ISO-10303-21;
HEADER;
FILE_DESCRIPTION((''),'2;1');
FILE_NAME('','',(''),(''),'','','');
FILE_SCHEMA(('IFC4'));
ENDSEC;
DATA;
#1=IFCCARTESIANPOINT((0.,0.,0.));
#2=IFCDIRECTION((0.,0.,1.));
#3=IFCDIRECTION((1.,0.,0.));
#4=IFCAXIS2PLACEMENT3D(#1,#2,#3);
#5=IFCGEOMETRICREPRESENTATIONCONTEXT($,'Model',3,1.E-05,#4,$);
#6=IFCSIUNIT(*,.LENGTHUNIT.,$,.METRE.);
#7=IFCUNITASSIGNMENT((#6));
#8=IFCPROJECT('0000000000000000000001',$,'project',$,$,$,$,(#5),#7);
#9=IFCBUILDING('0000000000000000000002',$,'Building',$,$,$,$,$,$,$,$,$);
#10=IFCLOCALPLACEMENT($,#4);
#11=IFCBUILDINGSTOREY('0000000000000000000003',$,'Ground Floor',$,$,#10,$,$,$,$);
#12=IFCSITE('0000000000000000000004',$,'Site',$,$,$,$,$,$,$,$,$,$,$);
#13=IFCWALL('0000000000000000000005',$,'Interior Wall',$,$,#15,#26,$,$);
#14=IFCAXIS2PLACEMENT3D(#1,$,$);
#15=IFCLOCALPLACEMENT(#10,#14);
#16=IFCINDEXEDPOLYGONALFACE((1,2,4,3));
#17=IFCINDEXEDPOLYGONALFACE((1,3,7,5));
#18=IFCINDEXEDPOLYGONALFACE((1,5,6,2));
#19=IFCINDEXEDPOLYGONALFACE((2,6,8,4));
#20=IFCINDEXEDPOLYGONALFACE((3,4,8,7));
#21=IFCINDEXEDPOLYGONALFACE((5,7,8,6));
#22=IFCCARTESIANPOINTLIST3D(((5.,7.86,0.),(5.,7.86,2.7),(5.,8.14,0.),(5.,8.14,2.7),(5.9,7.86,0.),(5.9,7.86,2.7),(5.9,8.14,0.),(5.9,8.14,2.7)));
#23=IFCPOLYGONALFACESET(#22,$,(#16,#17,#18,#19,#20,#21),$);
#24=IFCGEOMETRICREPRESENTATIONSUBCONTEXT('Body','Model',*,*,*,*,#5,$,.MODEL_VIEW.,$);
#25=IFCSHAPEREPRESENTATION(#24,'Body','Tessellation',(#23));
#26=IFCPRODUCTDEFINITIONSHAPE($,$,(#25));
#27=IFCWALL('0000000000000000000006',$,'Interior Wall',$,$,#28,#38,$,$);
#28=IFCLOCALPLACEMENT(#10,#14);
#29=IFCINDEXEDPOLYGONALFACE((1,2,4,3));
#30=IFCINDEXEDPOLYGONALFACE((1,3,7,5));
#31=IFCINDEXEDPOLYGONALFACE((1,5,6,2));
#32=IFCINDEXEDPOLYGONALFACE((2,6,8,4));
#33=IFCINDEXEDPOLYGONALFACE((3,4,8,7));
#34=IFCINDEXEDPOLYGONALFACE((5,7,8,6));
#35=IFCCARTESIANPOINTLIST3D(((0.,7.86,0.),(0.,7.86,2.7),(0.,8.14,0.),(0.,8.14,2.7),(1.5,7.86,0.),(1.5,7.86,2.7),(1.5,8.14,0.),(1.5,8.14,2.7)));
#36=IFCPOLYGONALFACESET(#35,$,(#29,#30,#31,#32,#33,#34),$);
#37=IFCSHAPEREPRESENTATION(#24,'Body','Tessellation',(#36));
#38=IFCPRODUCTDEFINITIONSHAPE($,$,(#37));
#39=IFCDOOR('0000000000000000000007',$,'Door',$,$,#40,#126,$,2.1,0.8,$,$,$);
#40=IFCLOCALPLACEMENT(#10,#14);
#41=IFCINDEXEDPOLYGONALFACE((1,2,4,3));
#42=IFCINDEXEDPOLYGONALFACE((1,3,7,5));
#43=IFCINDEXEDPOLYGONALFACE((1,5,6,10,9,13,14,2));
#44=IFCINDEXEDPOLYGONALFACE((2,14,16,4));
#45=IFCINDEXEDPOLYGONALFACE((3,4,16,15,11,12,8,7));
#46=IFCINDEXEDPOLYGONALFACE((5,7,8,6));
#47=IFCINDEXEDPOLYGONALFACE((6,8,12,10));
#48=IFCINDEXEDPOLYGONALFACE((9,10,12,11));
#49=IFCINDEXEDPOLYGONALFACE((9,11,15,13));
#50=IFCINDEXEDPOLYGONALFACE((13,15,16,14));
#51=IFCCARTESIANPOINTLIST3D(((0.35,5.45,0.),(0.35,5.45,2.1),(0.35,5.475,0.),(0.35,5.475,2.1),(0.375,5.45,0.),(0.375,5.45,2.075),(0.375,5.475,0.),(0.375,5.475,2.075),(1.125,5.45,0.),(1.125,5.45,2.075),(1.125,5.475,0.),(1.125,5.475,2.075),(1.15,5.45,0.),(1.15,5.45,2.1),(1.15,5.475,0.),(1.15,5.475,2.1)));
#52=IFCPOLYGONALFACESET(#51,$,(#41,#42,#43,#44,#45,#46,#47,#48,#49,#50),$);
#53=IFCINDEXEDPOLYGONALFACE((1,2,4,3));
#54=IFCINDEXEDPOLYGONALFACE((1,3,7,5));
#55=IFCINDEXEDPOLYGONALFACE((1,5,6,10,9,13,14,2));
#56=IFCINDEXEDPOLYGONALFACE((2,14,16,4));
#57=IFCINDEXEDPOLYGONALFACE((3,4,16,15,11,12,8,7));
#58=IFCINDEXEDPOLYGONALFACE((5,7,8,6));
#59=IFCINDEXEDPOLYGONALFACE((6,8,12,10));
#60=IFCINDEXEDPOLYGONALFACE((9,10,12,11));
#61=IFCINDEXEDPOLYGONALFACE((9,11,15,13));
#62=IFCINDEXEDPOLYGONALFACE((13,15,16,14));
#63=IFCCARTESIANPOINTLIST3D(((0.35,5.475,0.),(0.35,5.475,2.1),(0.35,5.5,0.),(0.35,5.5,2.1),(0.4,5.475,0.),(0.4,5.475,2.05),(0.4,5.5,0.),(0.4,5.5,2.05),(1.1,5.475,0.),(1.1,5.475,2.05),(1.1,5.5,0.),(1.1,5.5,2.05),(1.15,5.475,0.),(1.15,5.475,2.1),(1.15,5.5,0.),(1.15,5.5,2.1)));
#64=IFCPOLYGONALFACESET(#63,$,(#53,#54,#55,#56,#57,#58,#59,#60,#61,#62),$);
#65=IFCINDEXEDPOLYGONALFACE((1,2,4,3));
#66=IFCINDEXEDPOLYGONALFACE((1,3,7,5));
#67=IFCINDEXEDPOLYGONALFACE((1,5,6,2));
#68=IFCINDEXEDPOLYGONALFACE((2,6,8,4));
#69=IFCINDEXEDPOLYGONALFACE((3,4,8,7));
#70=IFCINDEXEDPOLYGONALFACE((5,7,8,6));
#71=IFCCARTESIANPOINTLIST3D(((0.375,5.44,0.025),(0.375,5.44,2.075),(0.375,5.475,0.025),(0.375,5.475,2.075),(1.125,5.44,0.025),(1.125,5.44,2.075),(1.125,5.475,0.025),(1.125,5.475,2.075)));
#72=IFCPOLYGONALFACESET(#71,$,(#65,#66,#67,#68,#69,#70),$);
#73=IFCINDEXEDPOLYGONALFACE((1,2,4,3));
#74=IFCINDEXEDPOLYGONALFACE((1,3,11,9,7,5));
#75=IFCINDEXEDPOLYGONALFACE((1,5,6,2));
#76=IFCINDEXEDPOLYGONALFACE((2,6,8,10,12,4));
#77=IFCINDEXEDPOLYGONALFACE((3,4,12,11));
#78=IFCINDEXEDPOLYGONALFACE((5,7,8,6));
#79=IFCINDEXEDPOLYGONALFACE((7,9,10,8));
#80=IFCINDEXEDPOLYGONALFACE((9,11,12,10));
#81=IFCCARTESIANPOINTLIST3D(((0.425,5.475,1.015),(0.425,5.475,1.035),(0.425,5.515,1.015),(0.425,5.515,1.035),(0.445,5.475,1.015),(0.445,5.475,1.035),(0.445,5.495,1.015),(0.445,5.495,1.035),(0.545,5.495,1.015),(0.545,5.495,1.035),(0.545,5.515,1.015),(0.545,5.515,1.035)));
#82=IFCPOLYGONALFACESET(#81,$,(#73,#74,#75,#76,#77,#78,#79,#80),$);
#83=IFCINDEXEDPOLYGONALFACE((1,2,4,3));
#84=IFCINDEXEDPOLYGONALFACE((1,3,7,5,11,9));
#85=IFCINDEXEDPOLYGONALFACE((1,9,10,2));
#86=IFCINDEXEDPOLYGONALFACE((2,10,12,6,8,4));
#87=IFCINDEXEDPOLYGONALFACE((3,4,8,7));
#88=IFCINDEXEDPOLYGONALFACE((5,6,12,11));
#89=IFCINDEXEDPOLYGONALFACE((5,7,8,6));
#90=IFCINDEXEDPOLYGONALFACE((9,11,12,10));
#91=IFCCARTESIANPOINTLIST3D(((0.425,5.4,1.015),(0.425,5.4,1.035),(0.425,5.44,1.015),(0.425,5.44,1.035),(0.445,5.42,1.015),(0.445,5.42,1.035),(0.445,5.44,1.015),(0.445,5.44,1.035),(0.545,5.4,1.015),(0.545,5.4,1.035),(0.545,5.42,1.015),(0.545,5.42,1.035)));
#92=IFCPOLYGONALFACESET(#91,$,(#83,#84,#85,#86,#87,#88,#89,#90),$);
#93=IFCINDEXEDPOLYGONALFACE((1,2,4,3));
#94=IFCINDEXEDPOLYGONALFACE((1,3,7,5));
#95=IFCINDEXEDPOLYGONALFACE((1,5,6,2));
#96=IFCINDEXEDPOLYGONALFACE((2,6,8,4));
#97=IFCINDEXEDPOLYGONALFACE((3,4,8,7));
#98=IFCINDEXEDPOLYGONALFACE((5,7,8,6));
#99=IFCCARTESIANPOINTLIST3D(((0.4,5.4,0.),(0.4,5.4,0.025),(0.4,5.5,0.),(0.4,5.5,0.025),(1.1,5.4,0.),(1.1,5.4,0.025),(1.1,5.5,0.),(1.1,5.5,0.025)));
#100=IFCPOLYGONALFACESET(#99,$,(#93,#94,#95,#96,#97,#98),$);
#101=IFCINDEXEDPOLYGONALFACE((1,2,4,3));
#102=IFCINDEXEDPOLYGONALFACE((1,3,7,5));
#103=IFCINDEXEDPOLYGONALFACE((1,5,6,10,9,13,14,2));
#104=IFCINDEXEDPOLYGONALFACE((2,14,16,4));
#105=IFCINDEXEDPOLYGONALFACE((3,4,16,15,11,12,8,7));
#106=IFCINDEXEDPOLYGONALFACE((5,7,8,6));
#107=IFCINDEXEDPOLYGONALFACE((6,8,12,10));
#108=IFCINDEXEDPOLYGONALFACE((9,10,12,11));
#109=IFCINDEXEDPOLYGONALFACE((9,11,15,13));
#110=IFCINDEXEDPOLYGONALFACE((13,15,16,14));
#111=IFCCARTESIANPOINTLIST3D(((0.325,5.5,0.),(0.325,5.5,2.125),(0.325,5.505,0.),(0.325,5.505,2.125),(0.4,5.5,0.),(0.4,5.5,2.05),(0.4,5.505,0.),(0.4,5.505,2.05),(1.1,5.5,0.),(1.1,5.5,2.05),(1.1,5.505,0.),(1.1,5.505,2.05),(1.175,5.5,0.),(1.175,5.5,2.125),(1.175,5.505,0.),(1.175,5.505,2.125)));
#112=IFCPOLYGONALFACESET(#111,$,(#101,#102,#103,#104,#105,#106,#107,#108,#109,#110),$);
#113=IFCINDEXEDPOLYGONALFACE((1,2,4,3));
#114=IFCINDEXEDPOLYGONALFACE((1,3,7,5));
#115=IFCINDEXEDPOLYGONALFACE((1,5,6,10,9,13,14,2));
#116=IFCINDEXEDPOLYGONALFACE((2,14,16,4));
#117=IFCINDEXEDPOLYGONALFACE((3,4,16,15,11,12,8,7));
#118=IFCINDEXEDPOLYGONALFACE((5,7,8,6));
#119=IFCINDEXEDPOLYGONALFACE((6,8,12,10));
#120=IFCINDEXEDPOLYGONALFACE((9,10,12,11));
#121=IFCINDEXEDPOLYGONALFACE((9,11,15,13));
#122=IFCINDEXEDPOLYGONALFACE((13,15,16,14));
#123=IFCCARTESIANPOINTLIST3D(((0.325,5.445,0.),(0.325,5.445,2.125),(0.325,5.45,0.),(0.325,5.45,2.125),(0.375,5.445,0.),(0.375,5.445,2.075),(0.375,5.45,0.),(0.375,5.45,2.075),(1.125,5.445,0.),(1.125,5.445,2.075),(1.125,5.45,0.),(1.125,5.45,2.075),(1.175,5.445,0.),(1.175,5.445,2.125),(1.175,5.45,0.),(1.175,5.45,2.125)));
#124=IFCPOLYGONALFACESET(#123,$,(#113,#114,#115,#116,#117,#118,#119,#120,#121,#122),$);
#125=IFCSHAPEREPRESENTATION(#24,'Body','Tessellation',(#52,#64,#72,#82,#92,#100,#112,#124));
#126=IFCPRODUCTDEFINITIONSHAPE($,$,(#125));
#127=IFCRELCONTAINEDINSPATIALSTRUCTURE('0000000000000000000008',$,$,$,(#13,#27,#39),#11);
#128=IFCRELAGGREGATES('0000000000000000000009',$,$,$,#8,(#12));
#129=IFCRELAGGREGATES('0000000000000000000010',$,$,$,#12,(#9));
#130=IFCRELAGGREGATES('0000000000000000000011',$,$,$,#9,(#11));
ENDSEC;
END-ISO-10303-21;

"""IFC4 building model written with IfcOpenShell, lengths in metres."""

from ifc_helpers import new_model, si_unit, frame, origin_with_axes, place, context, subcontext, project, spatial, line, indexed_curve, outline, extrude, element, save


model = new_model("IFC4")

# Units and contexts
model_context = context("Model", 3, precision=1e-05, world=origin_with_axes())
body_context = subcontext(model_context, "Body", "Model", "MODEL_VIEW")
ifc_project = project(units=[si_unit("LENGTHUNIT", "METRE")], contexts=[model_context])

# Site, building, storey
site = spatial("IfcSite", under=ifc_project, Name="Site")
building = spatial("IfcBuilding", under=site, Name="Building")
storey_placement = place(None, origin_with_axes())
storey = spatial("IfcBuildingStorey", under=building, at=storey_placement, Name="Ground Floor")

# Walls
for number, where, z_axis, x_axis, name in (
    (1, (5.9, 8.0, 0.0), (0.0, 0.0, 1.0), (-1.0, 0.0, 0.0), "Interior Wall"),
):
    element("IfcWall", number, at=place(storey_placement, frame(where, z_axis=z_axis, x_axis=x_axis)), inside=storey, Name=name, context=body_context, shape_type="SweptSolid", body=[
        extrude(outline(indexed_curve([(0.0, 0.0), (0.0, 0.28), (0.9, 0.28), (0.9, 0.0), (0.0, 0.0)], self_intersect=False)), frame((0.0, -0.14, 0.0), z_axis=(0.0, 0.0, 1.0), x_axis=(1.0, 0.0, 0.0)), (0.0, 0.0, 1.0), 2.7),
    ])
wall_1_placement = place(storey_placement, frame((1.5, 8.0, 0.0), z_axis=(0.0, 0.0, 1.0), x_axis=(-1.0, 0.0, 0.0)))
element("IfcWall", 2, at=wall_1_placement, inside=storey, Name="Interior Wall", context=body_context, shape_type="SweptSolid", body=[
    extrude(outline(indexed_curve([(0.0, 0.0), (0.0, 0.28), (1.5, 0.28), (1.5, 0.0), (0.0, 0.0)], self_intersect=False)), frame((0.0, -0.14, 0.0), z_axis=(0.0, 0.0, 1.0), x_axis=(1.0, 0.0, 0.0)), (0.0, 0.0, 1.0), 2.7),
])

# Door
door_1_placement = place(storey_placement, frame((1.15, 5.5, 0.0), z_axis=(0.0, 0.0, 1.0), x_axis=(-1.0, 0.0, 0.0)))
element("IfcDoor", 3, at=door_1_placement, inside=storey, Name="Door", OverallHeight=2.1, OverallWidth=0.8, context=body_context, shape_type="SweptSolid", body=[
    extrude(outline(indexed_curve([(0.0, 0.0), (0.0, 2.1), (0.8, 2.1), (0.8, 0.0), (0.775, 0.0), (0.775, 2.075), (0.025, 2.075), (0.025, 0.0)], segments=[line(1, 2, 3, 4, 5, 6, 7, 8, 1)])), frame((0.0, 0.025, 0.0), z_axis=(0.0, -1.0, 0.0), x_axis=(1.0, 0.0, 0.0)), (0.0, 0.0, -1.0), 0.025),
    extrude(outline(indexed_curve([(0.0, 0.0), (0.0, 2.1), (0.8, 2.1), (0.8, 0.0), (0.75, 0.0), (0.75, 2.05), (0.05, 2.05), (0.05, 0.0)], segments=[line(1, 2, 3, 4, 5, 6, 7, 8, 1)])), frame((0.0, 0.0, 0.0), z_axis=(0.0, -1.0, 0.0), x_axis=(1.0, 0.0, 0.0)), (0.0, 0.0, -1.0), 0.025),
    extrude(outline(indexed_curve([(0.0, 0.0), (0.75, 0.0), (0.75, 0.035), (0.0, 0.035)], segments=[line(1, 2, 3, 4, 1)])), frame((0.025, 0.025, 0.025), z_axis=(0.0, 0.0, 1.0), x_axis=(1.0, 0.0, 0.0)), (0.0, 0.0, 1.0), 2.05),
    extrude(outline(indexed_curve([(0.0, 0.0), (0.0, -0.04), (-0.12, -0.04), (-0.12, -0.02), (-0.02, -0.02), (-0.02, 0.0)], segments=[line(1, 2, 3, 4, 5, 6, 1)])), frame((0.725, 0.025, 1.015), z_axis=(0.0, 0.0, 1.0), x_axis=(1.0, 0.0, 0.0)), (0.0, 0.0, 1.0), 0.02),
    extrude(outline(indexed_curve([(0.0, 0.0), (0.0, 0.04), (-0.12, 0.04), (-0.12, 0.02), (-0.02, 0.02), (-0.02, 0.0)], segments=[line(1, 2, 3, 4, 5, 6, 1)])), frame((0.725, 0.06, 1.015), z_axis=(0.0, 0.0, 1.0), x_axis=(1.0, 0.0, 0.0)), (0.0, 0.0, 1.0), 0.02),
    extrude(outline(indexed_curve([(0.0, 0.0), (0.7, 0.0), (0.7, 0.1), (0.0, 0.1)], segments=[line(1, 2, 3, 4, 1)])), frame((0.05, 0.0, 0.0), z_axis=(0.0, 0.0, 1.0), x_axis=(1.0, 0.0, 0.0)), (0.0, 0.0, 1.0), 0.025),
    extrude(outline(indexed_curve([(0.0, 0.0), (0.0, 2.125), (0.85, 2.125), (0.85, 0.0), (0.775, 0.0), (0.775, 2.05), (0.075, 2.05), (0.075, 0.0)], segments=[line(1, 2, 3, 4, 5, 6, 7, 8, 1)])), frame((-0.025, -0.005, 0.0), z_axis=(0.0, -1.0, 0.0), x_axis=(1.0, 0.0, 0.0)), (0.0, 0.0, -1.0), 0.005),
    extrude(outline(indexed_curve([(0.0, 0.0), (0.0, 2.125), (0.85, 2.125), (0.85, 0.0), (0.8, 0.0), (0.8, 2.075), (0.05, 2.075), (0.05, 0.0)], segments=[line(1, 2, 3, 4, 5, 6, 7, 8, 1)])), frame((-0.025, 0.05, 0.0), z_axis=(0.0, -1.0, 0.0), x_axis=(1.0, 0.0, 0.0)), (0.0, 0.0, -1.0), 0.005),
])

save(model, "model.ifc")
